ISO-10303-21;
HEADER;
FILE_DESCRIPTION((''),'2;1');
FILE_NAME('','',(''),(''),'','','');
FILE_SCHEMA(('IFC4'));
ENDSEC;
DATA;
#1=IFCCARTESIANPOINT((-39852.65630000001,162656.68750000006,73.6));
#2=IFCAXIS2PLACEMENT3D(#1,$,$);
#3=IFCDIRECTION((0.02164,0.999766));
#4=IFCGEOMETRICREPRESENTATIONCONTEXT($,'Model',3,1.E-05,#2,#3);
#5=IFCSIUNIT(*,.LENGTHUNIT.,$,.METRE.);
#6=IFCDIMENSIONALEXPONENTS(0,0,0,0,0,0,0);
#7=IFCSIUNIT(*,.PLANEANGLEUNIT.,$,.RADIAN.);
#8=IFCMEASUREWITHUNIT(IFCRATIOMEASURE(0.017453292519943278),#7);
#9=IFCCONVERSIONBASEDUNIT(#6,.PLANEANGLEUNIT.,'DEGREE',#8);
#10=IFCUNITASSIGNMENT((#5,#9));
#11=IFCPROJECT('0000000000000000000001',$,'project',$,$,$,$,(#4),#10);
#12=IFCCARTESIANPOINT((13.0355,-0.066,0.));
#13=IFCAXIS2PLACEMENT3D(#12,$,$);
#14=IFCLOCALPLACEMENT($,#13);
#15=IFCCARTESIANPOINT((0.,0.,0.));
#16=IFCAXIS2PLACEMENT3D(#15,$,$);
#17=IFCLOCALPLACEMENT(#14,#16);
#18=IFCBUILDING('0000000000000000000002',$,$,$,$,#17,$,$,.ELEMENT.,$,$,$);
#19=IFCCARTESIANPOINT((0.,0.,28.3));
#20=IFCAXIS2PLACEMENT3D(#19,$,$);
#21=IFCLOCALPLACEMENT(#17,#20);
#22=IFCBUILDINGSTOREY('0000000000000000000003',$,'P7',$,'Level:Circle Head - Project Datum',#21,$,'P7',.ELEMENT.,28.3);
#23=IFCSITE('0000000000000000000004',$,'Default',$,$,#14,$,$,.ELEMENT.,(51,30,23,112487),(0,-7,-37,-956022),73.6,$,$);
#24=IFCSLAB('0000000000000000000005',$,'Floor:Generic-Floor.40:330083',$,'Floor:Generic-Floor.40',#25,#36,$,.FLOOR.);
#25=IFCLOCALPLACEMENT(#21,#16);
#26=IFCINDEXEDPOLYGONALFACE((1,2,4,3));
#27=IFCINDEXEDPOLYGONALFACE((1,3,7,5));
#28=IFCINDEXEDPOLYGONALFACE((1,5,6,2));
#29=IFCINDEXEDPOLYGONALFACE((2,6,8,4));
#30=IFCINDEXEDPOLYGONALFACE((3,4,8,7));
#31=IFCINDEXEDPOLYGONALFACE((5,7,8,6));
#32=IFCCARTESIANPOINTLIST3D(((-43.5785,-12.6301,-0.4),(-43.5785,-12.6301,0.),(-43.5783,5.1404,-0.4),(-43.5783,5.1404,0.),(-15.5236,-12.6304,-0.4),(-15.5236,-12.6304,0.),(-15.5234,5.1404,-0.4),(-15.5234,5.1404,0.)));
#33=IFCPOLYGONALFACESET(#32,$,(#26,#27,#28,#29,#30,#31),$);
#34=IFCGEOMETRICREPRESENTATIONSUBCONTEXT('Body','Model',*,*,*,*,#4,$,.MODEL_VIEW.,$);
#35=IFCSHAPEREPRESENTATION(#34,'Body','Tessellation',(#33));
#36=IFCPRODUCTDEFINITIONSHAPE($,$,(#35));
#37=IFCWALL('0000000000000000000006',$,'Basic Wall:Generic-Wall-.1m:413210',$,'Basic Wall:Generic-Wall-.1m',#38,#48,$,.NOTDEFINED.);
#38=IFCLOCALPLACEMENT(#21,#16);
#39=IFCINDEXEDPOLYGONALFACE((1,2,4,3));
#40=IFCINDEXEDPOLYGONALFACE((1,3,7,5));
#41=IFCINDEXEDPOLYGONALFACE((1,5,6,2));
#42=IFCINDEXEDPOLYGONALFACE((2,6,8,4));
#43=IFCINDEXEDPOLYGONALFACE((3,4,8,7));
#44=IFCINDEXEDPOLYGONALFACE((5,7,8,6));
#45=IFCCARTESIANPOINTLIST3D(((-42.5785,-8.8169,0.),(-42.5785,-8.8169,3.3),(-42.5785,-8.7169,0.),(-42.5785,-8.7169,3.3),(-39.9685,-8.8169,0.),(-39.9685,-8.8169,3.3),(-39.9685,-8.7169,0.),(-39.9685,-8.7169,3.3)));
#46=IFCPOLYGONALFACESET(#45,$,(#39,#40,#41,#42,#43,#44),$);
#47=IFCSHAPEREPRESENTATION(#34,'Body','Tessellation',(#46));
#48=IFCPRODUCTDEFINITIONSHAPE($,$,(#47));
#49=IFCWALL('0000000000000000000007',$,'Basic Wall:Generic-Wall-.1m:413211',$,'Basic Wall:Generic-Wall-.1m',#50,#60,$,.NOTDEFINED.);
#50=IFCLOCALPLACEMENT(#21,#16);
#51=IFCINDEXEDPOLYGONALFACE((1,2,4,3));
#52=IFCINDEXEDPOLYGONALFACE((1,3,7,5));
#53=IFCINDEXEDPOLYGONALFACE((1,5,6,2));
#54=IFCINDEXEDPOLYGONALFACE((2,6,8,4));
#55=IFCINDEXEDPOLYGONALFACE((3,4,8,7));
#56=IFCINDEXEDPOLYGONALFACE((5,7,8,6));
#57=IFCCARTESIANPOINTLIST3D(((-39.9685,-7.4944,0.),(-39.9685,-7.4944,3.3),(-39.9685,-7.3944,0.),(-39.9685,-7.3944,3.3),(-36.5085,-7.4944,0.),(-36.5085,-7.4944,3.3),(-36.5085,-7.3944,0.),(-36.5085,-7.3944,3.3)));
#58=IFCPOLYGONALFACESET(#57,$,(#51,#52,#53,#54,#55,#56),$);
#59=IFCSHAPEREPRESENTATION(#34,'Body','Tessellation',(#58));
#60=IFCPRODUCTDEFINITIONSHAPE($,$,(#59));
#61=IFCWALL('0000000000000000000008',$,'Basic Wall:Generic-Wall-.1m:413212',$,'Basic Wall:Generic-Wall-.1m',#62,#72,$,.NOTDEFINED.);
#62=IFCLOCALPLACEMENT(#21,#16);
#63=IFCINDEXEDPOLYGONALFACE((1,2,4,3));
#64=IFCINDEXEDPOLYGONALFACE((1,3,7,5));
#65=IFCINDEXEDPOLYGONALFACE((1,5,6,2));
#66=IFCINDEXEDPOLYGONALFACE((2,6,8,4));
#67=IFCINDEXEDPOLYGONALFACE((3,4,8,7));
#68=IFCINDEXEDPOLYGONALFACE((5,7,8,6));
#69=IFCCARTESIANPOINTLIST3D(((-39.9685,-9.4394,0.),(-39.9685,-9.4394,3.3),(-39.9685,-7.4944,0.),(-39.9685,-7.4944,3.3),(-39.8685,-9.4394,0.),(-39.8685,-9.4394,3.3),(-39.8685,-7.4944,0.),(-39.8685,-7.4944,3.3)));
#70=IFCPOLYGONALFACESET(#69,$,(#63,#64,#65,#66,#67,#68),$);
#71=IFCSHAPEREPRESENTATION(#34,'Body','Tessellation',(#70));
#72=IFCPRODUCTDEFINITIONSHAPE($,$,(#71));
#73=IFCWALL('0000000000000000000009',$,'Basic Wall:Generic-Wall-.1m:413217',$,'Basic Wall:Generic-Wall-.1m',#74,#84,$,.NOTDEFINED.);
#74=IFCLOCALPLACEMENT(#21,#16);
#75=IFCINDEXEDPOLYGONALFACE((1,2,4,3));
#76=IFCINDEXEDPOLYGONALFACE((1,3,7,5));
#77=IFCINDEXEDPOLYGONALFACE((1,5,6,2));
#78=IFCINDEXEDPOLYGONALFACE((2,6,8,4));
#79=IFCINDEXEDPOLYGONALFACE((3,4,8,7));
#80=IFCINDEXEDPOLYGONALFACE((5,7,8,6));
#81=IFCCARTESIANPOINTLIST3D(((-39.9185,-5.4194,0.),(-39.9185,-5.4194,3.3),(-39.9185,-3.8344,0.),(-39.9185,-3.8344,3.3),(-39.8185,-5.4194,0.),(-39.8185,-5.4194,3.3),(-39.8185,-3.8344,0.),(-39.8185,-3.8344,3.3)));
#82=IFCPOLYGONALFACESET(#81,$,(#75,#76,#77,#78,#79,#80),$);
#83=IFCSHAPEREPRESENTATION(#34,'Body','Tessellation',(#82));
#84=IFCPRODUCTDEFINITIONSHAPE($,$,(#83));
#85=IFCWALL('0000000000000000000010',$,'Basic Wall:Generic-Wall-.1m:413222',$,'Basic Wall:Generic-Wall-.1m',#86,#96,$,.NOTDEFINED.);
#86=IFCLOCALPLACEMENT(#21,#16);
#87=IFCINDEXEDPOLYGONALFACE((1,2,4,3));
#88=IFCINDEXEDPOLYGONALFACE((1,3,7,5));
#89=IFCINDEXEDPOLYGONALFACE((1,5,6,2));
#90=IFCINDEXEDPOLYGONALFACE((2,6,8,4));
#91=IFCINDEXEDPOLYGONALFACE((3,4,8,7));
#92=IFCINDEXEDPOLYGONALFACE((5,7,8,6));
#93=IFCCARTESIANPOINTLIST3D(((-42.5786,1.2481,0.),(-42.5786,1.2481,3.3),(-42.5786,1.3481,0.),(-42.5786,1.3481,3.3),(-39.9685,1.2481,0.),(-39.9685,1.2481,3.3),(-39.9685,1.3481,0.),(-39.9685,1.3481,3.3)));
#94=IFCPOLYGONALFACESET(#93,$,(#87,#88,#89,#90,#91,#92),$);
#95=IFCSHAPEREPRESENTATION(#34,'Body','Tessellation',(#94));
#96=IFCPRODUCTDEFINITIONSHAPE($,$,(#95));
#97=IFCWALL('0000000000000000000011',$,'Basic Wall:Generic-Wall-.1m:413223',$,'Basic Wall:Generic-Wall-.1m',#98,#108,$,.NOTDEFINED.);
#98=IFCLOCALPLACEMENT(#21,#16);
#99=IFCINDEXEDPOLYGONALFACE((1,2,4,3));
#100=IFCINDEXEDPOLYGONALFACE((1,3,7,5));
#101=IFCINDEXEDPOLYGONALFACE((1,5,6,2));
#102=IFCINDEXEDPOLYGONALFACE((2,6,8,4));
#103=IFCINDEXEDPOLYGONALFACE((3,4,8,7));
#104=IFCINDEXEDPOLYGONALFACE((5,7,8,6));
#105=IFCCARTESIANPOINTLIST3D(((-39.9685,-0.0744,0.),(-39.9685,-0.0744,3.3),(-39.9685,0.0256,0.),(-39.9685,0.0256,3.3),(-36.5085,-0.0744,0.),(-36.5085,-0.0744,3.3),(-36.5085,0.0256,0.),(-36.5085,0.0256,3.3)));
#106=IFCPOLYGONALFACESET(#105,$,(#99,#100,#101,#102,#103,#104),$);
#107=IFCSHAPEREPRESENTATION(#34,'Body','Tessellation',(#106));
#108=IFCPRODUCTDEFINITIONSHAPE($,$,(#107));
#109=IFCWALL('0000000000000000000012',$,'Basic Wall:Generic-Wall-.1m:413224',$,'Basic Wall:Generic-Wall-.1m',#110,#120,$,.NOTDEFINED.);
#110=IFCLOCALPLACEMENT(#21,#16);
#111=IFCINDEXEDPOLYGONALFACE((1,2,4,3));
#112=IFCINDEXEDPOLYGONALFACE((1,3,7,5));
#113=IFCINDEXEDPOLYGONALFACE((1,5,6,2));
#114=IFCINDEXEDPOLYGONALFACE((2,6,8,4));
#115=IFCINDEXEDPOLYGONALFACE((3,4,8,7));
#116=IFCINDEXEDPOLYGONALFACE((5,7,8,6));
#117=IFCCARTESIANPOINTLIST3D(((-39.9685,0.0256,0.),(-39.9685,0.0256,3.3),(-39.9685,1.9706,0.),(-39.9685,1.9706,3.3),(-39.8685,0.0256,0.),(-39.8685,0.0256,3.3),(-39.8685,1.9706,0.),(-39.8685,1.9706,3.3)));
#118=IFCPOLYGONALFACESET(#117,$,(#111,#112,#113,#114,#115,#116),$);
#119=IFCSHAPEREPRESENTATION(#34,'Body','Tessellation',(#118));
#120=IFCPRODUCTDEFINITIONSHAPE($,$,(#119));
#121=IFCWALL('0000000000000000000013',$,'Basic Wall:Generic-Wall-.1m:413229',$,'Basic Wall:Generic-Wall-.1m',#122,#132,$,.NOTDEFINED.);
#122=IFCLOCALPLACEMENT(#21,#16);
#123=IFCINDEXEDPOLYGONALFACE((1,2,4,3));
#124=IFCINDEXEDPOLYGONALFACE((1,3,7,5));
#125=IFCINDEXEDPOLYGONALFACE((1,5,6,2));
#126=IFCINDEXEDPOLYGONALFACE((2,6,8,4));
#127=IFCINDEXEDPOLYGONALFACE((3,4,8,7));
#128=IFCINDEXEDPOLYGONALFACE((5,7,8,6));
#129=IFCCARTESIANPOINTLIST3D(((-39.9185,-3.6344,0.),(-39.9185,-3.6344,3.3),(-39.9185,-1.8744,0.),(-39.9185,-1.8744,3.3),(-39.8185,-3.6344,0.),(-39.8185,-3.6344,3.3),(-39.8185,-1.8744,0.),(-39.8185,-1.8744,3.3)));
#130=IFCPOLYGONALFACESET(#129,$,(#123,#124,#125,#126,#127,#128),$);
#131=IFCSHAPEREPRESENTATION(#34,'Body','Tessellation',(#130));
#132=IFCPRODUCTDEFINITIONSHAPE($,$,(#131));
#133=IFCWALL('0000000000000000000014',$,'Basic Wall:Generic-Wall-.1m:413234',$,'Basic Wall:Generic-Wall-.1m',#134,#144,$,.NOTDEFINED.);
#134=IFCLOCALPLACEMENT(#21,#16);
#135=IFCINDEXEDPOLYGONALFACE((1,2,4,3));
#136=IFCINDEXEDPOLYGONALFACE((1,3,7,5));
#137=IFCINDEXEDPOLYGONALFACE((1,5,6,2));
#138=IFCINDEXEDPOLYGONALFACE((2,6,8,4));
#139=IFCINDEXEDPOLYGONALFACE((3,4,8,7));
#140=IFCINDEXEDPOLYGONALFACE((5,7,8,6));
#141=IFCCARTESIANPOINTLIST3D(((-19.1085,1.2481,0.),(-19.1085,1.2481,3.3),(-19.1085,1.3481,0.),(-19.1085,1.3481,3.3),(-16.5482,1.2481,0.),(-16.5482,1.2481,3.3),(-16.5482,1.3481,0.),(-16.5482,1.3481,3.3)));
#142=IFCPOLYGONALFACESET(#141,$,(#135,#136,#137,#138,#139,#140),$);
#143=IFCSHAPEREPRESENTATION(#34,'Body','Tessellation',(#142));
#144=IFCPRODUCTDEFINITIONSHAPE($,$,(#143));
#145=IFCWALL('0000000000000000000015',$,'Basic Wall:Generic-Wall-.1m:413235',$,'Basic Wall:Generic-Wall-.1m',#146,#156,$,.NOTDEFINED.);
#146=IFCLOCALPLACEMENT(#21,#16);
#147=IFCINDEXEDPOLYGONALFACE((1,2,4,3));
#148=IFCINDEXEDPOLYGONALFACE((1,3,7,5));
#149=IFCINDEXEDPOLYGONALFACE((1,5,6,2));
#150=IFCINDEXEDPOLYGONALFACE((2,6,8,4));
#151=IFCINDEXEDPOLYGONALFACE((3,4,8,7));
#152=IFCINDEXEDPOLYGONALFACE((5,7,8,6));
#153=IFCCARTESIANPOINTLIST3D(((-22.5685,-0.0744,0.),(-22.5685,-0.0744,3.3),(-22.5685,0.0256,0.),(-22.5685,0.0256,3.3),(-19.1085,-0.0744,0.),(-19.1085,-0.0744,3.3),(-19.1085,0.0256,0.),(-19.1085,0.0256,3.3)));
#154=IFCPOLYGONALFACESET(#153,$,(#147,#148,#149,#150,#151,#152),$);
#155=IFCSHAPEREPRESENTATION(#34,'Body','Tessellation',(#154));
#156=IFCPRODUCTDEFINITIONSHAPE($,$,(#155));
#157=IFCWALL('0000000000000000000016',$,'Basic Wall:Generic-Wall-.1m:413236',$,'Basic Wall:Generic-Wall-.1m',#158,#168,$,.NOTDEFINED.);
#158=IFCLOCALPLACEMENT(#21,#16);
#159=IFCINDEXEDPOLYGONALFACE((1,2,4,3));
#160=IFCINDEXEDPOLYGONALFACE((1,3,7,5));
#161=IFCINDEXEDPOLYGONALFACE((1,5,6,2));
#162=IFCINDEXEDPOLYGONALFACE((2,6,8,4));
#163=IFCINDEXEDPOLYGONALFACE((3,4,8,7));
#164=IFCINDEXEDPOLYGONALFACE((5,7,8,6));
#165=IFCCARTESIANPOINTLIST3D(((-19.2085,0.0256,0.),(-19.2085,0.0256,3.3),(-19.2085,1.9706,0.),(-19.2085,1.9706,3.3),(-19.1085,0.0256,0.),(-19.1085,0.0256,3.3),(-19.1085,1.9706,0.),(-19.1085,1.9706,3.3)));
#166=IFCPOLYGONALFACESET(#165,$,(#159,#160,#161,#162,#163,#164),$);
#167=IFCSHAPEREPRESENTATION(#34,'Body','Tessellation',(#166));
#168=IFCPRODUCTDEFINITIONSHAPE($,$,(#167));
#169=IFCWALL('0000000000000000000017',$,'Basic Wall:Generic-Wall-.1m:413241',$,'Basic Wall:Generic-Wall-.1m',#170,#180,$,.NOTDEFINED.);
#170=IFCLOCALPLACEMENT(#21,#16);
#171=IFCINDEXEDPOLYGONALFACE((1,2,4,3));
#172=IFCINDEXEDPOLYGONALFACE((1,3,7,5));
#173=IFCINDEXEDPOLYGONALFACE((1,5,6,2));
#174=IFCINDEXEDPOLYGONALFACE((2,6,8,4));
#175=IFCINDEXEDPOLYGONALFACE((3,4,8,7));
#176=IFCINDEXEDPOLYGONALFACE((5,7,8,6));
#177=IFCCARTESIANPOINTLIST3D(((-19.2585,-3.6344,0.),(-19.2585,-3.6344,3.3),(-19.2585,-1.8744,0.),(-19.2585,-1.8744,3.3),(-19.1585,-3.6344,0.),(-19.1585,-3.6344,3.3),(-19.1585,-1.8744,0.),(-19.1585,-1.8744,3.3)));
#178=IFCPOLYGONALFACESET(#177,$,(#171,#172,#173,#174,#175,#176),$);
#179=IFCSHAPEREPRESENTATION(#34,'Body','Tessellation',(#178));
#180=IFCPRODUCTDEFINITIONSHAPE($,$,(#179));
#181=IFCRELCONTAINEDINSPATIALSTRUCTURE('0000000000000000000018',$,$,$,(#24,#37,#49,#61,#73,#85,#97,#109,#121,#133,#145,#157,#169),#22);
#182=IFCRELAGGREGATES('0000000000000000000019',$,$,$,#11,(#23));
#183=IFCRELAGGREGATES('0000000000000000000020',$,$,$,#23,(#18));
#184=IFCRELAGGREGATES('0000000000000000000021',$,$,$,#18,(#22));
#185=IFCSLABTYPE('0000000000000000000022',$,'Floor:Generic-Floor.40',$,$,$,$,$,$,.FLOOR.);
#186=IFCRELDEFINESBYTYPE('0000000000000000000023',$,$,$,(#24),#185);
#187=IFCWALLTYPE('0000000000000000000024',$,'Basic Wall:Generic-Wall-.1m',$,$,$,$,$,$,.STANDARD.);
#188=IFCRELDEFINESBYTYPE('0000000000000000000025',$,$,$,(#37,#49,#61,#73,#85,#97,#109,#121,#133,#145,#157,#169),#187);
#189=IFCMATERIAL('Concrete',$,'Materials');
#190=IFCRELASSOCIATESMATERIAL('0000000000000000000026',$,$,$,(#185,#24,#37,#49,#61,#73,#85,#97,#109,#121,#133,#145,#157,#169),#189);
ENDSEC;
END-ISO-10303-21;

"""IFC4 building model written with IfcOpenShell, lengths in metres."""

from ifc_helpers import new_model, entity, si_unit, converted_unit, direction, frame, origin, place, context, subcontext, project, spatial, indexed_curve, outline, extrude, material, type_object, element, save


model = new_model("IFC4")

# Units and contexts
model_context = context("Model", 3, precision=1e-05, world=frame((-39852.65630000001, 162656.68750000006, 73.6)), true_north=direction((0.02164, 0.999766)))
body_context = subcontext(model_context, "Body", "Model", "MODEL_VIEW")
ifc_project = project(units=[si_unit("LENGTHUNIT", "METRE"), converted_unit("PLANEANGLEUNIT", "DEGREE", entity("IfcRatioMeasure", 0.017453292519943278), si_unit("PLANEANGLEUNIT", "RADIAN"), dimensions=[0, 0, 0, 0, 0, 0, 0])], contexts=[model_context])

# Site, building, storey
site_placement = place(None, frame((13.0355, -0.066, 0.0)))
site = spatial("IfcSite", under=ifc_project, at=site_placement, Name="Default", CompositionType="ELEMENT", RefLatitude=(51, 30, 23, 112487), RefLongitude=(0, -7, -37, -956022), RefElevation=73.6)
building_placement = place(site_placement, origin())
building = spatial("IfcBuilding", under=site, at=building_placement, CompositionType="ELEMENT")
storey_placement = place(building_placement, frame((0.0, 0.0, 28.3)))
storey = spatial("IfcBuildingStorey", under=building, at=storey_placement, Name="P7", ObjectType="Level:Circle Head - Project Datum", LongName="P7", CompositionType="ELEMENT", Elevation=28.3)

# Shared definitions
ifc_material = material(Name="Concrete", Category="Materials")

# Slab
slab_type = type_object("IfcSlabType", Name="Floor:Generic-Floor.40", PredefinedType="FLOOR", material=ifc_material)
slab_placement = place(storey_placement, origin())
element("IfcSlab", 1, at=slab_placement, inside=storey, type_object=slab_type, material=ifc_material, Name="Floor:Generic-Floor.40:330083", ObjectType="Floor:Generic-Floor.40", PredefinedType="FLOOR", context=body_context, shape_type="SweptSolid", body=[
    extrude(outline(indexed_curve([(-14.0274, -8.8853), (14.0275, -8.8853), (14.0274, 8.8855), (-14.0275, 8.8852), (-14.0274, -8.8853)], self_intersect=False)), frame((-29.5509, -3.7449, 0.0), z_axis=(0.0, 0.0, -1.0), x_axis=(1.0, 0.0, 0.0)), (0.0, 0.0, 1.0), 0.4),
])

# Walls
wall_type = type_object("IfcWallType", Name="Basic Wall:Generic-Wall-.1m", PredefinedType="STANDARD")
wall_1_placement = place(storey_placement, frame((-39.9685, -8.7669, 0.0), z_axis=(0.0, 0.0, 1.0), x_axis=(-1.0, 0.0, 0.0)))
element("IfcWall", 2, at=wall_1_placement, inside=storey, type_object=wall_type, material=ifc_material, Name="Basic Wall:Generic-Wall-.1m:413210", ObjectType="Basic Wall:Generic-Wall-.1m", PredefinedType="NOTDEFINED", context=body_context, shape_type="SweptSolid", body=[
    extrude(outline(indexed_curve([(2.61, 0.05), (0.0, 0.05), (0.0, -0.05), (2.61, -0.05), (2.61, 0.05)], self_intersect=False)), origin(), (0.0, 0.0, 1.0), 3.3),
])
wall_2_placement = place(storey_placement, frame((-36.5085, -7.4444, 0.0), z_axis=(0.0, 0.0, 1.0), x_axis=(-1.0, 0.0, 0.0)))
element("IfcWall", 3, at=wall_2_placement, inside=storey, type_object=wall_type, material=ifc_material, Name="Basic Wall:Generic-Wall-.1m:413211", ObjectType="Basic Wall:Generic-Wall-.1m", PredefinedType="NOTDEFINED", context=body_context, shape_type="SweptSolid", body=[
    extrude(outline(indexed_curve([(3.46, 0.05), (0.0, 0.05), (0.0, -0.05), (3.46, -0.05), (3.46, 0.05)], self_intersect=False)), origin(), (0.0, 0.0, 1.0), 3.3),
])
wall_3_placement = place(storey_placement, frame((-39.9185, -7.4944, 0.0), z_axis=(0.0, 0.0, 1.0), x_axis=(0.0, -1.0, 0.0)))
element("IfcWall", 4, at=wall_3_placement, inside=storey, type_object=wall_type, material=ifc_material, Name="Basic Wall:Generic-Wall-.1m:413212", ObjectType="Basic Wall:Generic-Wall-.1m", PredefinedType="NOTDEFINED", context=body_context, shape_type="SweptSolid", body=[
    extrude(outline(indexed_curve([(1.945, 0.05), (0.0, 0.05), (0.0, -0.05), (1.945, -0.05), (1.945, 0.05)], self_intersect=False)), origin(), (0.0, 0.0, 1.0), 3.3),
])
wall_4_placement = place(storey_placement, frame((-39.8685, -5.4194, 0.0), z_axis=(0.0, 0.0, 1.0), x_axis=(0.0, 1.0, 0.0)))
element("IfcWall", 5, at=wall_4_placement, inside=storey, type_object=wall_type, material=ifc_material, Name="Basic Wall:Generic-Wall-.1m:413217", ObjectType="Basic Wall:Generic-Wall-.1m", PredefinedType="NOTDEFINED", context=body_context, shape_type="SweptSolid", body=[
    extrude(outline(indexed_curve([(1.585, 0.05), (0.0, 0.05), (0.0, -0.05), (1.585, -0.05), (1.585, 0.05)], self_intersect=False)), origin(), (0.0, 0.0, 1.0), 3.3),
])
wall_5_placement = place(storey_placement, frame((-39.9685, 1.2981, 0.0), z_axis=(0.0, 0.0, 1.0), x_axis=(-1.0, 0.0, 0.0)))
element("IfcWall", 6, at=wall_5_placement, inside=storey, type_object=wall_type, material=ifc_material, Name="Basic Wall:Generic-Wall-.1m:413222", ObjectType="Basic Wall:Generic-Wall-.1m", PredefinedType="NOTDEFINED", context=body_context, shape_type="SweptSolid", body=[
    extrude(outline(indexed_curve([(2.6101, 0.05), (0.0, 0.05), (0.0, -0.05), (2.6101, -0.05), (2.6101, 0.05)], self_intersect=False)), origin(), (0.0, 0.0, 1.0), 3.3),
])
wall_6_placement = place(storey_placement, frame((-36.5085, -0.0244, 0.0), z_axis=(0.0, 0.0, 1.0), x_axis=(-1.0, 0.0, 0.0)))
element("IfcWall", 7, at=wall_6_placement, inside=storey, type_object=wall_type, material=ifc_material, Name="Basic Wall:Generic-Wall-.1m:413223", ObjectType="Basic Wall:Generic-Wall-.1m", PredefinedType="NOTDEFINED", context=body_context, shape_type="SweptSolid", body=[
    extrude(outline(indexed_curve([(3.46, 0.05), (0.0, 0.05), (0.0, -0.05), (3.46, -0.05), (3.46, 0.05)], self_intersect=False)), origin(), (0.0, 0.0, 1.0), 3.3),
])
wall_7_placement = place(storey_placement, frame((-39.9185, 0.0256, 0.0), z_axis=(0.0, 0.0, 1.0), x_axis=(0.0, 1.0, 0.0)))
element("IfcWall", 8, at=wall_7_placement, inside=storey, type_object=wall_type, material=ifc_material, Name="Basic Wall:Generic-Wall-.1m:413224", ObjectType="Basic Wall:Generic-Wall-.1m", PredefinedType="NOTDEFINED", context=body_context, shape_type="SweptSolid", body=[
    extrude(outline(indexed_curve([(1.945, 0.05), (0.0, 0.05), (0.0, -0.05), (1.945, -0.05), (1.945, 0.05)], self_intersect=False)), origin(), (0.0, 0.0, 1.0), 3.3),
])
wall_8_placement = place(storey_placement, frame((-39.8685, -1.8744, 0.0), z_axis=(0.0, 0.0, 1.0), x_axis=(0.0, -1.0, 0.0)))
element("IfcWall", 9, at=wall_8_placement, inside=storey, type_object=wall_type, material=ifc_material, Name="Basic Wall:Generic-Wall-.1m:413229", ObjectType="Basic Wall:Generic-Wall-.1m", PredefinedType="NOTDEFINED", context=body_context, shape_type="SweptSolid", body=[
    extrude(outline(indexed_curve([(1.76, 0.05), (0.0, 0.05), (0.0, -0.05), (1.76, -0.05), (1.76, 0.05)], self_intersect=False)), origin(), (0.0, 0.0, 1.0), 3.3),
])
wall_9_placement = place(storey_placement, frame((-19.1085, 1.2981, 0.0)))
element("IfcWall", 10, at=wall_9_placement, inside=storey, type_object=wall_type, material=ifc_material, Name="Basic Wall:Generic-Wall-.1m:413234", ObjectType="Basic Wall:Generic-Wall-.1m", PredefinedType="NOTDEFINED", context=body_context, shape_type="SweptSolid", body=[
    extrude(outline(indexed_curve([(2.5602, 0.05), (0.0, 0.05), (0.0, -0.05), (2.5602, -0.05), (2.5602, 0.05)], self_intersect=False)), origin(), (0.0, 0.0, 1.0), 3.3),
])
wall_10_placement = place(storey_placement, frame((-22.5685, -0.0244, 0.0)))
element("IfcWall", 11, at=wall_10_placement, inside=storey, type_object=wall_type, material=ifc_material, Name="Basic Wall:Generic-Wall-.1m:413235", ObjectType="Basic Wall:Generic-Wall-.1m", PredefinedType="NOTDEFINED", context=body_context, shape_type="SweptSolid", body=[
    extrude(outline(indexed_curve([(3.46, 0.05), (0.0, 0.05), (0.0, -0.05), (3.46, -0.05), (3.46, 0.05)], self_intersect=False)), origin(), (0.0, 0.0, 1.0), 3.3),
])
wall_11_placement = place(storey_placement, frame((-19.1585, 0.0256, 0.0), z_axis=(0.0, 0.0, 1.0), x_axis=(0.0, 1.0, 0.0)))
element("IfcWall", 12, at=wall_11_placement, inside=storey, type_object=wall_type, material=ifc_material, Name="Basic Wall:Generic-Wall-.1m:413236", ObjectType="Basic Wall:Generic-Wall-.1m", PredefinedType="NOTDEFINED", context=body_context, shape_type="SweptSolid", body=[
    extrude(outline(indexed_curve([(1.945, 0.05), (0.0, 0.05), (0.0, -0.05), (1.945, -0.05), (1.945, 0.05)], self_intersect=False)), origin(), (0.0, 0.0, 1.0), 3.3),
])
wall_12_placement = place(storey_placement, frame((-19.2085, -1.8744, 0.0), z_axis=(0.0, 0.0, 1.0), x_axis=(0.0, -1.0, 0.0)))
element("IfcWall", 13, at=wall_12_placement, inside=storey, type_object=wall_type, material=ifc_material, Name="Basic Wall:Generic-Wall-.1m:413241", ObjectType="Basic Wall:Generic-Wall-.1m", PredefinedType="NOTDEFINED", context=body_context, shape_type="SweptSolid", body=[
    extrude(outline(indexed_curve([(1.76, 0.05), (0.0, 0.05), (0.0, -0.05), (1.76, -0.05), (1.76, 0.05)], self_intersect=False)), origin(), (0.0, 0.0, 1.0), 3.3),
])

save(model, "model.ifc")
